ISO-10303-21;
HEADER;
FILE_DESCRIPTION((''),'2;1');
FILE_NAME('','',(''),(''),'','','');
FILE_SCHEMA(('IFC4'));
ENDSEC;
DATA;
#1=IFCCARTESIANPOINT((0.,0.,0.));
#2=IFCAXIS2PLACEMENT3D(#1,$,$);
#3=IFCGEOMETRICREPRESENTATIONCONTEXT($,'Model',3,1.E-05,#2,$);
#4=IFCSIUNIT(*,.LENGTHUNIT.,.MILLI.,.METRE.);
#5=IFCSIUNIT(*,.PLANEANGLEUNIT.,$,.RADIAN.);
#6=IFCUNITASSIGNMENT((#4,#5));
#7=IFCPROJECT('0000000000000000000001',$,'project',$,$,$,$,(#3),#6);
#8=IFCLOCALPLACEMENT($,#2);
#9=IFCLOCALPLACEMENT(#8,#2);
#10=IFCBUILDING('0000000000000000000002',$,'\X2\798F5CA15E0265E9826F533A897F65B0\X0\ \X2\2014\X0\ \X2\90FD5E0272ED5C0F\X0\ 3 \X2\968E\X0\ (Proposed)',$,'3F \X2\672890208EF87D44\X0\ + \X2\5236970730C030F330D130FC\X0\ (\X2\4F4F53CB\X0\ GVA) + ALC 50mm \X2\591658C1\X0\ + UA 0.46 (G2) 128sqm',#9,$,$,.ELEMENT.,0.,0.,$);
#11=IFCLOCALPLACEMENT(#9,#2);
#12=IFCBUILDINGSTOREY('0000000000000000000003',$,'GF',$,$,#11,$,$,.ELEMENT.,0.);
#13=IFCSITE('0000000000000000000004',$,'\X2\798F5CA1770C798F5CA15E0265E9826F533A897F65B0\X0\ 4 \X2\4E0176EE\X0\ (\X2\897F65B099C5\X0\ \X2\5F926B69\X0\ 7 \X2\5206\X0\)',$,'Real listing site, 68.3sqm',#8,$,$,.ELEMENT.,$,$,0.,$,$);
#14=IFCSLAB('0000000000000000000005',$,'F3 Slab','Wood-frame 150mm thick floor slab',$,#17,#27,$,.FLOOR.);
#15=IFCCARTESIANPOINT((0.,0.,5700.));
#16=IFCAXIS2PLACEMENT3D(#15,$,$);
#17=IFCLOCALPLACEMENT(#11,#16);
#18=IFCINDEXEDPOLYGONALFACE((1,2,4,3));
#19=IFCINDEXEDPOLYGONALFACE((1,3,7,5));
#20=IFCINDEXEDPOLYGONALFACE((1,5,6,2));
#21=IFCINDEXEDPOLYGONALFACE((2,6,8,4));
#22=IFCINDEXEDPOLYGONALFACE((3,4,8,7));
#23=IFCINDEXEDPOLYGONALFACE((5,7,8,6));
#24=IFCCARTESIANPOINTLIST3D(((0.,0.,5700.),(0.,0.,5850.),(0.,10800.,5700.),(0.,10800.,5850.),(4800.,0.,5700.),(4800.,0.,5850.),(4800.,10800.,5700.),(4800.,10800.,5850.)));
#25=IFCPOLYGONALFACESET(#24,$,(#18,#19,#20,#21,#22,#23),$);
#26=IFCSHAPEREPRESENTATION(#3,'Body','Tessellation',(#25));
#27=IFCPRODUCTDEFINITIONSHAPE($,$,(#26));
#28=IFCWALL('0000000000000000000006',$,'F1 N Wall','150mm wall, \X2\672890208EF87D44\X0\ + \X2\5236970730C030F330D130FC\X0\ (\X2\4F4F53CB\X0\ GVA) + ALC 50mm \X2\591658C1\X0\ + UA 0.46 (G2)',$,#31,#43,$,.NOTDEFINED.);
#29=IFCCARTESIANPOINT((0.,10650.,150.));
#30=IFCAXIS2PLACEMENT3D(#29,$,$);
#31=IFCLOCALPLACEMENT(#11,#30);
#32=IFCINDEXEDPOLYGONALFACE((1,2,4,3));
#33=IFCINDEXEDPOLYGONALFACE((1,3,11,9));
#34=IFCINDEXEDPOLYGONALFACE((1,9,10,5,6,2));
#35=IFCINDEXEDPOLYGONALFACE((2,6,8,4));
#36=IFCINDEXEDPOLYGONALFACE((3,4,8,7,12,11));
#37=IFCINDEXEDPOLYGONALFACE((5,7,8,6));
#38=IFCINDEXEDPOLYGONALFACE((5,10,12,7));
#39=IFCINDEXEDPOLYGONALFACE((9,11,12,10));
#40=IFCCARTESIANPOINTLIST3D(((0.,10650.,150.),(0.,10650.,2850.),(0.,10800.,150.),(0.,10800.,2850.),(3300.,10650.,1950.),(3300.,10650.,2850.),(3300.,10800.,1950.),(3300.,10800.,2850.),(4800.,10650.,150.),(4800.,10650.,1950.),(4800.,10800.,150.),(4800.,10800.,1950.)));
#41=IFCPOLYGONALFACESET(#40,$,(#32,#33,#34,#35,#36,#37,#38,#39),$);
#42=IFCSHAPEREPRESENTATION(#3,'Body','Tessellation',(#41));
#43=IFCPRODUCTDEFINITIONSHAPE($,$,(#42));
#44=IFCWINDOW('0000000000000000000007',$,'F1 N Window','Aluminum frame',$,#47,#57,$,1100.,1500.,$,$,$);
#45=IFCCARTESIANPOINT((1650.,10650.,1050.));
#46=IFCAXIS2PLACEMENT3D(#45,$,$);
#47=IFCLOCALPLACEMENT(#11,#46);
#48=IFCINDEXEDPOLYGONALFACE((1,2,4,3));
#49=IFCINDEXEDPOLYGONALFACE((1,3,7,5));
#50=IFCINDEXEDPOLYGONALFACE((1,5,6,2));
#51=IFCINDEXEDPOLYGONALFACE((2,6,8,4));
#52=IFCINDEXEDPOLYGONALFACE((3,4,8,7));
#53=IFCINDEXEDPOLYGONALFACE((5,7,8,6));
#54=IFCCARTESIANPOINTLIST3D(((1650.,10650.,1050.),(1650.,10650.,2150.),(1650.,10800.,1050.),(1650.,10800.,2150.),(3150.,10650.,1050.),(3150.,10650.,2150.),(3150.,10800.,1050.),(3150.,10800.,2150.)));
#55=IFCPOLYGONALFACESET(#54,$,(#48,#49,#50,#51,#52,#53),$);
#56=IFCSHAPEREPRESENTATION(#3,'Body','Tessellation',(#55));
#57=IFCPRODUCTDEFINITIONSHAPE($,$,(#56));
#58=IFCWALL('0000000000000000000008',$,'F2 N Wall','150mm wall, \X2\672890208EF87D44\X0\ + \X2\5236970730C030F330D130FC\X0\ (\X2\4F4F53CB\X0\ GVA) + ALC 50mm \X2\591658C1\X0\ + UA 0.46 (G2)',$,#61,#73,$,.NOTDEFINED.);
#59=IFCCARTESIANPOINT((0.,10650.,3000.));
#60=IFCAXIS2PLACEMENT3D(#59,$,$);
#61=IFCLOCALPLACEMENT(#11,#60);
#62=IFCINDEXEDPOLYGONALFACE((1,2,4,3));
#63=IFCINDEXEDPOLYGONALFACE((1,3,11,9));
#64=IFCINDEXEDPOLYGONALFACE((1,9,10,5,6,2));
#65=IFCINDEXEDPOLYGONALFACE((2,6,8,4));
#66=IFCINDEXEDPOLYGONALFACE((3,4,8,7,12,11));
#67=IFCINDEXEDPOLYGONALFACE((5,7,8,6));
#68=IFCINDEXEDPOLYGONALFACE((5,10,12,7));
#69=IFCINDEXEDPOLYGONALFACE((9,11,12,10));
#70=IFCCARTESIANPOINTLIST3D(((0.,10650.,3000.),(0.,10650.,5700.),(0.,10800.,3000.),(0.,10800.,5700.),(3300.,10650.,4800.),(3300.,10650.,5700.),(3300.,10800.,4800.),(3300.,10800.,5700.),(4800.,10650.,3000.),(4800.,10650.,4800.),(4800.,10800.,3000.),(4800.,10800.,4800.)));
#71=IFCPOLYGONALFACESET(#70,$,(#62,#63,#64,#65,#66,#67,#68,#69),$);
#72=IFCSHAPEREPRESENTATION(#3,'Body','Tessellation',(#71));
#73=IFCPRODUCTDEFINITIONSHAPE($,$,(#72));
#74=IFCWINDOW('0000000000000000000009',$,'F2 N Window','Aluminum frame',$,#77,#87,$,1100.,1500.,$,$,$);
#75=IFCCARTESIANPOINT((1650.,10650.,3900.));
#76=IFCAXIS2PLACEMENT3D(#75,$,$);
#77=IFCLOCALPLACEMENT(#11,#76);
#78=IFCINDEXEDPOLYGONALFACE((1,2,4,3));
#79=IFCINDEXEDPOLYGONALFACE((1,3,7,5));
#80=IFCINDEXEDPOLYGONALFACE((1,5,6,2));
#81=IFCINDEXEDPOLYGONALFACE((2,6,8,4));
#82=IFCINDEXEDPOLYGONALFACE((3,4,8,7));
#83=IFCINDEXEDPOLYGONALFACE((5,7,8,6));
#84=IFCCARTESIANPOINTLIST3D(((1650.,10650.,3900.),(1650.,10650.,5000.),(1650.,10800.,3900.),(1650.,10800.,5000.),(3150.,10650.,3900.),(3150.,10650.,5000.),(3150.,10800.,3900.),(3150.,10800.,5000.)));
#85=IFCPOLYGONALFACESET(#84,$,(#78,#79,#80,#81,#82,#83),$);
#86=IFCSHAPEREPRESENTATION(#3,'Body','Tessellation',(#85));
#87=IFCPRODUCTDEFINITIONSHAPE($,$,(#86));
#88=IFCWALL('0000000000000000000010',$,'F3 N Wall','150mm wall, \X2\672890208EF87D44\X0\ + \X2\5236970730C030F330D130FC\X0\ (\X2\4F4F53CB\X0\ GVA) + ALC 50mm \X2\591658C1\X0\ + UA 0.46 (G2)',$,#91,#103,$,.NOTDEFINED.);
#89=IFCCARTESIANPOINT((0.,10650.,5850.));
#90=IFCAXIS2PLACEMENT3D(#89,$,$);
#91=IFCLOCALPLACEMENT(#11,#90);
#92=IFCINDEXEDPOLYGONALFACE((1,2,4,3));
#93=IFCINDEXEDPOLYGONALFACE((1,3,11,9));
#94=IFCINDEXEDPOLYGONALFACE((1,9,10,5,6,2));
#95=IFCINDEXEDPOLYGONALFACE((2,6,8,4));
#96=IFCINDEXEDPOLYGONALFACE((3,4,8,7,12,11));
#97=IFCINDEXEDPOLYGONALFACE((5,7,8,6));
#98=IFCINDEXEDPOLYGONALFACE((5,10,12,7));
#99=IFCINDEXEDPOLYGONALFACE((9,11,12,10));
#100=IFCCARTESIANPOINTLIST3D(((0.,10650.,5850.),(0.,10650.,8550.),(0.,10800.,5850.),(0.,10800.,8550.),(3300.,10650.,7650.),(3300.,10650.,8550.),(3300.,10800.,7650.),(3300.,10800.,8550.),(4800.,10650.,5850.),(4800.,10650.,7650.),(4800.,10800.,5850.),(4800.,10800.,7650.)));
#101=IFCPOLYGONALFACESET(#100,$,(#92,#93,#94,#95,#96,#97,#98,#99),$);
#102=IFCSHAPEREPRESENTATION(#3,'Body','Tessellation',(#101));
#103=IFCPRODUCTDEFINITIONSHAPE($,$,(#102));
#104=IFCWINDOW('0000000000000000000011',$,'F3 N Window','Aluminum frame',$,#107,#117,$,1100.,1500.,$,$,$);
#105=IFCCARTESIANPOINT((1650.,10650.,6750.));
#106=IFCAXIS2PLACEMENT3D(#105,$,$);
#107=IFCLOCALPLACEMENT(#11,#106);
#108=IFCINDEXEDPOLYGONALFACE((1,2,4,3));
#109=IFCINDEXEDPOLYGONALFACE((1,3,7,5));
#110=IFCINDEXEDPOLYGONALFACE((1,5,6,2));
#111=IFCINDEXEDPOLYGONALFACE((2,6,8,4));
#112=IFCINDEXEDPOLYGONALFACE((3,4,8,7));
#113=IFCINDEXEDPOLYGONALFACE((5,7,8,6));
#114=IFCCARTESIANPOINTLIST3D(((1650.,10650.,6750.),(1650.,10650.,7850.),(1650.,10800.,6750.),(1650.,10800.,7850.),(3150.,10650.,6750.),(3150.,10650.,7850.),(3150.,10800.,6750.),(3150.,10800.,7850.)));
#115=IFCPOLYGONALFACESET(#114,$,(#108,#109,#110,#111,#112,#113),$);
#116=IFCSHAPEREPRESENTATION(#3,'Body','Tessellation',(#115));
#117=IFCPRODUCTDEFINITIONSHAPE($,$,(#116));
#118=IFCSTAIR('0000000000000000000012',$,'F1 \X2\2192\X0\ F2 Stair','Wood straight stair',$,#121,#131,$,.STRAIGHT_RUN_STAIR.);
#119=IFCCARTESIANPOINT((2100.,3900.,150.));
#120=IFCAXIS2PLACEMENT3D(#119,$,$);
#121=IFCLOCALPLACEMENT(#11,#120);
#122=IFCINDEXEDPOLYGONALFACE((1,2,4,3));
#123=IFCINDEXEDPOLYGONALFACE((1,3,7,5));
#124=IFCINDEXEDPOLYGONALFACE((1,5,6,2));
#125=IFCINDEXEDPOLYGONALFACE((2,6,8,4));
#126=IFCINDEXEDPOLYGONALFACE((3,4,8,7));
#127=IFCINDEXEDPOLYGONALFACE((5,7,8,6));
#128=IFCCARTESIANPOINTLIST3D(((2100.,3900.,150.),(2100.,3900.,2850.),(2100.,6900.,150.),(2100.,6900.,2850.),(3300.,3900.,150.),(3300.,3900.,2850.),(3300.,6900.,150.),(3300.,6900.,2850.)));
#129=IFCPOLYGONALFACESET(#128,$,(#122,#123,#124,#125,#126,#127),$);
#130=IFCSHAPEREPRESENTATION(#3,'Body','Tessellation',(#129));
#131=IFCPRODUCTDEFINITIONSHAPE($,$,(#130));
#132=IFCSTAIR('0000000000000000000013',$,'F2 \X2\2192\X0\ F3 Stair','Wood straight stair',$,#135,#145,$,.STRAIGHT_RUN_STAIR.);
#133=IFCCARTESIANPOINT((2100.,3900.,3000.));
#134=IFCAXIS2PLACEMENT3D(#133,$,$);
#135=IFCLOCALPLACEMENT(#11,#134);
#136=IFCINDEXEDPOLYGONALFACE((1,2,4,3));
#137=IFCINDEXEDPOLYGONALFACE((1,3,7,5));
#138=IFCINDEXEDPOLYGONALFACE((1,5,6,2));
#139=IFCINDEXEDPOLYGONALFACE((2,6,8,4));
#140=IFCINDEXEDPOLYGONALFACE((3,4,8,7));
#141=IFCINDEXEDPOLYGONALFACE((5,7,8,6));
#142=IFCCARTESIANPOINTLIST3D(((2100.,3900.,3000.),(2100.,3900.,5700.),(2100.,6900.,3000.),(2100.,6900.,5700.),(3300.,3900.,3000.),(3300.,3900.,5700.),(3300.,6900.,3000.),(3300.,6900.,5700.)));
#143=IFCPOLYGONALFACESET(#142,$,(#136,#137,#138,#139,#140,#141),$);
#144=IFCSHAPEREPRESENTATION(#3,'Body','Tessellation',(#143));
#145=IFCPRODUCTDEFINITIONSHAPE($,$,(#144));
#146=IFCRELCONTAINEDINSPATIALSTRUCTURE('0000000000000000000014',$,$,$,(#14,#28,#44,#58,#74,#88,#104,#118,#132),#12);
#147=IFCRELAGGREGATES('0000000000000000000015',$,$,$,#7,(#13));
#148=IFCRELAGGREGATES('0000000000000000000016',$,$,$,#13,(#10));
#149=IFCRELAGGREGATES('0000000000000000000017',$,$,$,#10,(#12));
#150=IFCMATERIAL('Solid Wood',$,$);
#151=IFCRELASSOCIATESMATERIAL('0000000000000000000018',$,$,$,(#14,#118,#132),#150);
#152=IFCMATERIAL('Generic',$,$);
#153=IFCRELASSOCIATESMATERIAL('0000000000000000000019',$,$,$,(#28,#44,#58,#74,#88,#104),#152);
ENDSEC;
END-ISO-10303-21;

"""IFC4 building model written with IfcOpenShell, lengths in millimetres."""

from ifc_helpers import new_model, si_unit, frame, frame_2d, origin, place, context, project, spatial, rectangle, extrude, material, element, fill, save


model = new_model("IFC4")

# Units and contexts
model_context = context("Model", 3, precision=1e-05, world=origin())
ifc_project = project(units=[si_unit("LENGTHUNIT", "METRE", prefix="MILLI"), si_unit("PLANEANGLEUNIT", "RADIAN")], contexts=[model_context])

# Site, building, storey
site_placement = place(None, origin())
site = spatial("IfcSite", under=ifc_project, at=site_placement, Name="福岡県福岡市早良区西新 4 丁目 (西新駅 徒歩 7 分)", ObjectType="Real listing site, 68.3sqm", CompositionType="ELEMENT", RefElevation=0.0)
building_placement = place(site_placement, origin())
building = spatial("IfcBuilding", under=site, at=building_placement, Name="福岡市早良区西新 — 都市狭小 3 階 (Proposed)", ObjectType="3F 木造軸組 + 制震ダンパー (住友 GVA) + ALC 50mm 外壁 + UA 0.46 (G2) 128sqm", CompositionType="ELEMENT", ElevationOfRefHeight=0.0, ElevationOfTerrain=0.0)
storey_placement = place(building_placement, origin())
storey = spatial("IfcBuildingStorey", under=building, at=storey_placement, Name="GF", CompositionType="ELEMENT", Elevation=0.0)

# Slab
ifc_material_1 = material(Name="Solid Wood")
slab_placement = place(storey_placement, frame((0.0, 0.0, 5700.0)))
element("IfcSlab", 1, at=slab_placement, inside=storey, material=ifc_material_1, Name="F3 Slab", Description="Wood-frame 150mm thick floor slab", PredefinedType="FLOOR", context=model_context, shape_type="SweptSolid", body=[
    extrude(rectangle(XDim=4800.0, YDim=10800.0, at=frame_2d((2400.0, 5400.0))), frame((0.0, 0.0, 5700.0)), (0.0, 0.0, 1.0), 150.0),
])

# Walls, openings, windows
ifc_material_2 = material(Name="Generic")
wall_1_placement = place(storey_placement, frame((0.0, 10650.0, 150.0)))
wall_1 = element("IfcWall", 2, at=wall_1_placement, inside=storey, material=ifc_material_2, Name="F1 N Wall", Description="150mm wall, 木造軸組 + 制震ダンパー (住友 GVA) + ALC 50mm 外壁 + UA 0.46 (G2)", PredefinedType="NOTDEFINED", context=model_context, shape_type="SweptSolid", body=[
    extrude(rectangle(XDim=4800.0, YDim=150.0, at=frame_2d((2400.0, 75.0))), frame((0.0, 10650.0, 150.0)), (0.0, 0.0, 1.0), 2700.0),
])
opening_1_placement = place(storey_placement, frame((1650.0, 10650.0, 1050.0)))
opening_1 = element("IfcOpeningElement", 3, at=opening_1_placement, cuts=wall_1, PredefinedType="NOTDEFINED", context=model_context, shape_type="SweptSolid", body=[
    extrude(rectangle(XDim=1500.0, YDim=150.0, at=frame_2d((750.0, 75.0))), frame((1650.0, 10650.0, 1050.0)), (0.0, 0.0, 1.0), 1100.0),
])
window_1_placement = place(storey_placement, frame((1650.0, 10650.0, 1050.0)))
window_1 = element("IfcWindow", 4, at=window_1_placement, inside=storey, material=ifc_material_2, Name="F1 N Window", Description="Aluminum frame", OverallHeight=1100.0, OverallWidth=1500.0, context=model_context, shape_type="SweptSolid", body=[
    extrude(rectangle(XDim=1500.0, YDim=150.0, at=frame_2d((750.0, 75.0))), frame((1650.0, 10650.0, 1050.0)), (0.0, 0.0, 1.0), 1100.0),
])
fill(opening_1, window_1)
wall_2_placement = place(storey_placement, frame((0.0, 10650.0, 3000.0)))
wall_2 = element("IfcWall", 5, at=wall_2_placement, inside=storey, material=ifc_material_2, Name="F2 N Wall", Description="150mm wall, 木造軸組 + 制震ダンパー (住友 GVA) + ALC 50mm 外壁 + UA 0.46 (G2)", PredefinedType="NOTDEFINED", context=model_context, shape_type="SweptSolid", body=[
    extrude(rectangle(XDim=4800.0, YDim=150.0, at=frame_2d((2400.0, 75.0))), frame((0.0, 10650.0, 3000.0)), (0.0, 0.0, 1.0), 2700.0),
])
opening_2_placement = place(storey_placement, frame((1650.0, 10650.0, 3900.0)))
opening_2 = element("IfcOpeningElement", 6, at=opening_2_placement, cuts=wall_2, PredefinedType="NOTDEFINED", context=model_context, shape_type="SweptSolid", body=[
    extrude(rectangle(XDim=1500.0, YDim=150.0, at=frame_2d((750.0, 75.0))), frame((1650.0, 10650.0, 3900.0)), (0.0, 0.0, 1.0), 1100.0),
])
window_2_placement = place(storey_placement, frame((1650.0, 10650.0, 3900.0)))
window_2 = element("IfcWindow", 7, at=window_2_placement, inside=storey, material=ifc_material_2, Name="F2 N Window", Description="Aluminum frame", OverallHeight=1100.0, OverallWidth=1500.0, context=model_context, shape_type="SweptSolid", body=[
    extrude(rectangle(XDim=1500.0, YDim=150.0, at=frame_2d((750.0, 75.0))), frame((1650.0, 10650.0, 3900.0)), (0.0, 0.0, 1.0), 1100.0),
])
fill(opening_2, window_2)
wall_3_placement = place(storey_placement, frame((0.0, 10650.0, 5850.0)))
wall_3 = element("IfcWall", 8, at=wall_3_placement, inside=storey, material=ifc_material_2, Name="F3 N Wall", Description="150mm wall, 木造軸組 + 制震ダンパー (住友 GVA) + ALC 50mm 外壁 + UA 0.46 (G2)", PredefinedType="NOTDEFINED", context=model_context, shape_type="SweptSolid", body=[
    extrude(rectangle(XDim=4800.0, YDim=150.0, at=frame_2d((2400.0, 75.0))), frame((0.0, 10650.0, 5850.0)), (0.0, 0.0, 1.0), 2700.0),
])
opening_3_placement = place(storey_placement, frame((1650.0, 10650.0, 6750.0)))
opening_3 = element("IfcOpeningElement", 9, at=opening_3_placement, cuts=wall_3, PredefinedType="NOTDEFINED", context=model_context, shape_type="SweptSolid", body=[
    extrude(rectangle(XDim=1500.0, YDim=150.0, at=frame_2d((750.0, 75.0))), frame((1650.0, 10650.0, 6750.0)), (0.0, 0.0, 1.0), 1100.0),
])
window_3_placement = place(storey_placement, frame((1650.0, 10650.0, 6750.0)))
window_3 = element("IfcWindow", 10, at=window_3_placement, inside=storey, material=ifc_material_2, Name="F3 N Window", Description="Aluminum frame", OverallHeight=1100.0, OverallWidth=1500.0, context=model_context, shape_type="SweptSolid", body=[
    extrude(rectangle(XDim=1500.0, YDim=150.0, at=frame_2d((750.0, 75.0))), frame((1650.0, 10650.0, 6750.0)), (0.0, 0.0, 1.0), 1100.0),
])
fill(opening_3, window_3)

# Stairs
stair_1_placement = place(storey_placement, frame((2100.0, 3900.0, 150.0)))
element("IfcStair", 11, at=stair_1_placement, inside=storey, material=ifc_material_1, Name="F1 → F2 Stair", Description="Wood straight stair", PredefinedType="STRAIGHT_RUN_STAIR", context=model_context, shape_type="SweptSolid", body=[
    extrude(rectangle(XDim=1200.0, YDim=3000.0, at=frame_2d((600.0, 1500.0))), frame((2100.0, 3900.0, 150.0)), (0.0, 0.0, 1.0), 2700.0),
])
stair_2_placement = place(storey_placement, frame((2100.0, 3900.0, 3000.0)))
element("IfcStair", 12, at=stair_2_placement, inside=storey, material=ifc_material_1, Name="F2 → F3 Stair", Description="Wood straight stair", PredefinedType="STRAIGHT_RUN_STAIR", context=model_context, shape_type="SweptSolid", body=[
    extrude(rectangle(XDim=1200.0, YDim=3000.0, at=frame_2d((600.0, 1500.0))), frame((2100.0, 3900.0, 3000.0)), (0.0, 0.0, 1.0), 2700.0),
])

save(model, "model.ifc")
